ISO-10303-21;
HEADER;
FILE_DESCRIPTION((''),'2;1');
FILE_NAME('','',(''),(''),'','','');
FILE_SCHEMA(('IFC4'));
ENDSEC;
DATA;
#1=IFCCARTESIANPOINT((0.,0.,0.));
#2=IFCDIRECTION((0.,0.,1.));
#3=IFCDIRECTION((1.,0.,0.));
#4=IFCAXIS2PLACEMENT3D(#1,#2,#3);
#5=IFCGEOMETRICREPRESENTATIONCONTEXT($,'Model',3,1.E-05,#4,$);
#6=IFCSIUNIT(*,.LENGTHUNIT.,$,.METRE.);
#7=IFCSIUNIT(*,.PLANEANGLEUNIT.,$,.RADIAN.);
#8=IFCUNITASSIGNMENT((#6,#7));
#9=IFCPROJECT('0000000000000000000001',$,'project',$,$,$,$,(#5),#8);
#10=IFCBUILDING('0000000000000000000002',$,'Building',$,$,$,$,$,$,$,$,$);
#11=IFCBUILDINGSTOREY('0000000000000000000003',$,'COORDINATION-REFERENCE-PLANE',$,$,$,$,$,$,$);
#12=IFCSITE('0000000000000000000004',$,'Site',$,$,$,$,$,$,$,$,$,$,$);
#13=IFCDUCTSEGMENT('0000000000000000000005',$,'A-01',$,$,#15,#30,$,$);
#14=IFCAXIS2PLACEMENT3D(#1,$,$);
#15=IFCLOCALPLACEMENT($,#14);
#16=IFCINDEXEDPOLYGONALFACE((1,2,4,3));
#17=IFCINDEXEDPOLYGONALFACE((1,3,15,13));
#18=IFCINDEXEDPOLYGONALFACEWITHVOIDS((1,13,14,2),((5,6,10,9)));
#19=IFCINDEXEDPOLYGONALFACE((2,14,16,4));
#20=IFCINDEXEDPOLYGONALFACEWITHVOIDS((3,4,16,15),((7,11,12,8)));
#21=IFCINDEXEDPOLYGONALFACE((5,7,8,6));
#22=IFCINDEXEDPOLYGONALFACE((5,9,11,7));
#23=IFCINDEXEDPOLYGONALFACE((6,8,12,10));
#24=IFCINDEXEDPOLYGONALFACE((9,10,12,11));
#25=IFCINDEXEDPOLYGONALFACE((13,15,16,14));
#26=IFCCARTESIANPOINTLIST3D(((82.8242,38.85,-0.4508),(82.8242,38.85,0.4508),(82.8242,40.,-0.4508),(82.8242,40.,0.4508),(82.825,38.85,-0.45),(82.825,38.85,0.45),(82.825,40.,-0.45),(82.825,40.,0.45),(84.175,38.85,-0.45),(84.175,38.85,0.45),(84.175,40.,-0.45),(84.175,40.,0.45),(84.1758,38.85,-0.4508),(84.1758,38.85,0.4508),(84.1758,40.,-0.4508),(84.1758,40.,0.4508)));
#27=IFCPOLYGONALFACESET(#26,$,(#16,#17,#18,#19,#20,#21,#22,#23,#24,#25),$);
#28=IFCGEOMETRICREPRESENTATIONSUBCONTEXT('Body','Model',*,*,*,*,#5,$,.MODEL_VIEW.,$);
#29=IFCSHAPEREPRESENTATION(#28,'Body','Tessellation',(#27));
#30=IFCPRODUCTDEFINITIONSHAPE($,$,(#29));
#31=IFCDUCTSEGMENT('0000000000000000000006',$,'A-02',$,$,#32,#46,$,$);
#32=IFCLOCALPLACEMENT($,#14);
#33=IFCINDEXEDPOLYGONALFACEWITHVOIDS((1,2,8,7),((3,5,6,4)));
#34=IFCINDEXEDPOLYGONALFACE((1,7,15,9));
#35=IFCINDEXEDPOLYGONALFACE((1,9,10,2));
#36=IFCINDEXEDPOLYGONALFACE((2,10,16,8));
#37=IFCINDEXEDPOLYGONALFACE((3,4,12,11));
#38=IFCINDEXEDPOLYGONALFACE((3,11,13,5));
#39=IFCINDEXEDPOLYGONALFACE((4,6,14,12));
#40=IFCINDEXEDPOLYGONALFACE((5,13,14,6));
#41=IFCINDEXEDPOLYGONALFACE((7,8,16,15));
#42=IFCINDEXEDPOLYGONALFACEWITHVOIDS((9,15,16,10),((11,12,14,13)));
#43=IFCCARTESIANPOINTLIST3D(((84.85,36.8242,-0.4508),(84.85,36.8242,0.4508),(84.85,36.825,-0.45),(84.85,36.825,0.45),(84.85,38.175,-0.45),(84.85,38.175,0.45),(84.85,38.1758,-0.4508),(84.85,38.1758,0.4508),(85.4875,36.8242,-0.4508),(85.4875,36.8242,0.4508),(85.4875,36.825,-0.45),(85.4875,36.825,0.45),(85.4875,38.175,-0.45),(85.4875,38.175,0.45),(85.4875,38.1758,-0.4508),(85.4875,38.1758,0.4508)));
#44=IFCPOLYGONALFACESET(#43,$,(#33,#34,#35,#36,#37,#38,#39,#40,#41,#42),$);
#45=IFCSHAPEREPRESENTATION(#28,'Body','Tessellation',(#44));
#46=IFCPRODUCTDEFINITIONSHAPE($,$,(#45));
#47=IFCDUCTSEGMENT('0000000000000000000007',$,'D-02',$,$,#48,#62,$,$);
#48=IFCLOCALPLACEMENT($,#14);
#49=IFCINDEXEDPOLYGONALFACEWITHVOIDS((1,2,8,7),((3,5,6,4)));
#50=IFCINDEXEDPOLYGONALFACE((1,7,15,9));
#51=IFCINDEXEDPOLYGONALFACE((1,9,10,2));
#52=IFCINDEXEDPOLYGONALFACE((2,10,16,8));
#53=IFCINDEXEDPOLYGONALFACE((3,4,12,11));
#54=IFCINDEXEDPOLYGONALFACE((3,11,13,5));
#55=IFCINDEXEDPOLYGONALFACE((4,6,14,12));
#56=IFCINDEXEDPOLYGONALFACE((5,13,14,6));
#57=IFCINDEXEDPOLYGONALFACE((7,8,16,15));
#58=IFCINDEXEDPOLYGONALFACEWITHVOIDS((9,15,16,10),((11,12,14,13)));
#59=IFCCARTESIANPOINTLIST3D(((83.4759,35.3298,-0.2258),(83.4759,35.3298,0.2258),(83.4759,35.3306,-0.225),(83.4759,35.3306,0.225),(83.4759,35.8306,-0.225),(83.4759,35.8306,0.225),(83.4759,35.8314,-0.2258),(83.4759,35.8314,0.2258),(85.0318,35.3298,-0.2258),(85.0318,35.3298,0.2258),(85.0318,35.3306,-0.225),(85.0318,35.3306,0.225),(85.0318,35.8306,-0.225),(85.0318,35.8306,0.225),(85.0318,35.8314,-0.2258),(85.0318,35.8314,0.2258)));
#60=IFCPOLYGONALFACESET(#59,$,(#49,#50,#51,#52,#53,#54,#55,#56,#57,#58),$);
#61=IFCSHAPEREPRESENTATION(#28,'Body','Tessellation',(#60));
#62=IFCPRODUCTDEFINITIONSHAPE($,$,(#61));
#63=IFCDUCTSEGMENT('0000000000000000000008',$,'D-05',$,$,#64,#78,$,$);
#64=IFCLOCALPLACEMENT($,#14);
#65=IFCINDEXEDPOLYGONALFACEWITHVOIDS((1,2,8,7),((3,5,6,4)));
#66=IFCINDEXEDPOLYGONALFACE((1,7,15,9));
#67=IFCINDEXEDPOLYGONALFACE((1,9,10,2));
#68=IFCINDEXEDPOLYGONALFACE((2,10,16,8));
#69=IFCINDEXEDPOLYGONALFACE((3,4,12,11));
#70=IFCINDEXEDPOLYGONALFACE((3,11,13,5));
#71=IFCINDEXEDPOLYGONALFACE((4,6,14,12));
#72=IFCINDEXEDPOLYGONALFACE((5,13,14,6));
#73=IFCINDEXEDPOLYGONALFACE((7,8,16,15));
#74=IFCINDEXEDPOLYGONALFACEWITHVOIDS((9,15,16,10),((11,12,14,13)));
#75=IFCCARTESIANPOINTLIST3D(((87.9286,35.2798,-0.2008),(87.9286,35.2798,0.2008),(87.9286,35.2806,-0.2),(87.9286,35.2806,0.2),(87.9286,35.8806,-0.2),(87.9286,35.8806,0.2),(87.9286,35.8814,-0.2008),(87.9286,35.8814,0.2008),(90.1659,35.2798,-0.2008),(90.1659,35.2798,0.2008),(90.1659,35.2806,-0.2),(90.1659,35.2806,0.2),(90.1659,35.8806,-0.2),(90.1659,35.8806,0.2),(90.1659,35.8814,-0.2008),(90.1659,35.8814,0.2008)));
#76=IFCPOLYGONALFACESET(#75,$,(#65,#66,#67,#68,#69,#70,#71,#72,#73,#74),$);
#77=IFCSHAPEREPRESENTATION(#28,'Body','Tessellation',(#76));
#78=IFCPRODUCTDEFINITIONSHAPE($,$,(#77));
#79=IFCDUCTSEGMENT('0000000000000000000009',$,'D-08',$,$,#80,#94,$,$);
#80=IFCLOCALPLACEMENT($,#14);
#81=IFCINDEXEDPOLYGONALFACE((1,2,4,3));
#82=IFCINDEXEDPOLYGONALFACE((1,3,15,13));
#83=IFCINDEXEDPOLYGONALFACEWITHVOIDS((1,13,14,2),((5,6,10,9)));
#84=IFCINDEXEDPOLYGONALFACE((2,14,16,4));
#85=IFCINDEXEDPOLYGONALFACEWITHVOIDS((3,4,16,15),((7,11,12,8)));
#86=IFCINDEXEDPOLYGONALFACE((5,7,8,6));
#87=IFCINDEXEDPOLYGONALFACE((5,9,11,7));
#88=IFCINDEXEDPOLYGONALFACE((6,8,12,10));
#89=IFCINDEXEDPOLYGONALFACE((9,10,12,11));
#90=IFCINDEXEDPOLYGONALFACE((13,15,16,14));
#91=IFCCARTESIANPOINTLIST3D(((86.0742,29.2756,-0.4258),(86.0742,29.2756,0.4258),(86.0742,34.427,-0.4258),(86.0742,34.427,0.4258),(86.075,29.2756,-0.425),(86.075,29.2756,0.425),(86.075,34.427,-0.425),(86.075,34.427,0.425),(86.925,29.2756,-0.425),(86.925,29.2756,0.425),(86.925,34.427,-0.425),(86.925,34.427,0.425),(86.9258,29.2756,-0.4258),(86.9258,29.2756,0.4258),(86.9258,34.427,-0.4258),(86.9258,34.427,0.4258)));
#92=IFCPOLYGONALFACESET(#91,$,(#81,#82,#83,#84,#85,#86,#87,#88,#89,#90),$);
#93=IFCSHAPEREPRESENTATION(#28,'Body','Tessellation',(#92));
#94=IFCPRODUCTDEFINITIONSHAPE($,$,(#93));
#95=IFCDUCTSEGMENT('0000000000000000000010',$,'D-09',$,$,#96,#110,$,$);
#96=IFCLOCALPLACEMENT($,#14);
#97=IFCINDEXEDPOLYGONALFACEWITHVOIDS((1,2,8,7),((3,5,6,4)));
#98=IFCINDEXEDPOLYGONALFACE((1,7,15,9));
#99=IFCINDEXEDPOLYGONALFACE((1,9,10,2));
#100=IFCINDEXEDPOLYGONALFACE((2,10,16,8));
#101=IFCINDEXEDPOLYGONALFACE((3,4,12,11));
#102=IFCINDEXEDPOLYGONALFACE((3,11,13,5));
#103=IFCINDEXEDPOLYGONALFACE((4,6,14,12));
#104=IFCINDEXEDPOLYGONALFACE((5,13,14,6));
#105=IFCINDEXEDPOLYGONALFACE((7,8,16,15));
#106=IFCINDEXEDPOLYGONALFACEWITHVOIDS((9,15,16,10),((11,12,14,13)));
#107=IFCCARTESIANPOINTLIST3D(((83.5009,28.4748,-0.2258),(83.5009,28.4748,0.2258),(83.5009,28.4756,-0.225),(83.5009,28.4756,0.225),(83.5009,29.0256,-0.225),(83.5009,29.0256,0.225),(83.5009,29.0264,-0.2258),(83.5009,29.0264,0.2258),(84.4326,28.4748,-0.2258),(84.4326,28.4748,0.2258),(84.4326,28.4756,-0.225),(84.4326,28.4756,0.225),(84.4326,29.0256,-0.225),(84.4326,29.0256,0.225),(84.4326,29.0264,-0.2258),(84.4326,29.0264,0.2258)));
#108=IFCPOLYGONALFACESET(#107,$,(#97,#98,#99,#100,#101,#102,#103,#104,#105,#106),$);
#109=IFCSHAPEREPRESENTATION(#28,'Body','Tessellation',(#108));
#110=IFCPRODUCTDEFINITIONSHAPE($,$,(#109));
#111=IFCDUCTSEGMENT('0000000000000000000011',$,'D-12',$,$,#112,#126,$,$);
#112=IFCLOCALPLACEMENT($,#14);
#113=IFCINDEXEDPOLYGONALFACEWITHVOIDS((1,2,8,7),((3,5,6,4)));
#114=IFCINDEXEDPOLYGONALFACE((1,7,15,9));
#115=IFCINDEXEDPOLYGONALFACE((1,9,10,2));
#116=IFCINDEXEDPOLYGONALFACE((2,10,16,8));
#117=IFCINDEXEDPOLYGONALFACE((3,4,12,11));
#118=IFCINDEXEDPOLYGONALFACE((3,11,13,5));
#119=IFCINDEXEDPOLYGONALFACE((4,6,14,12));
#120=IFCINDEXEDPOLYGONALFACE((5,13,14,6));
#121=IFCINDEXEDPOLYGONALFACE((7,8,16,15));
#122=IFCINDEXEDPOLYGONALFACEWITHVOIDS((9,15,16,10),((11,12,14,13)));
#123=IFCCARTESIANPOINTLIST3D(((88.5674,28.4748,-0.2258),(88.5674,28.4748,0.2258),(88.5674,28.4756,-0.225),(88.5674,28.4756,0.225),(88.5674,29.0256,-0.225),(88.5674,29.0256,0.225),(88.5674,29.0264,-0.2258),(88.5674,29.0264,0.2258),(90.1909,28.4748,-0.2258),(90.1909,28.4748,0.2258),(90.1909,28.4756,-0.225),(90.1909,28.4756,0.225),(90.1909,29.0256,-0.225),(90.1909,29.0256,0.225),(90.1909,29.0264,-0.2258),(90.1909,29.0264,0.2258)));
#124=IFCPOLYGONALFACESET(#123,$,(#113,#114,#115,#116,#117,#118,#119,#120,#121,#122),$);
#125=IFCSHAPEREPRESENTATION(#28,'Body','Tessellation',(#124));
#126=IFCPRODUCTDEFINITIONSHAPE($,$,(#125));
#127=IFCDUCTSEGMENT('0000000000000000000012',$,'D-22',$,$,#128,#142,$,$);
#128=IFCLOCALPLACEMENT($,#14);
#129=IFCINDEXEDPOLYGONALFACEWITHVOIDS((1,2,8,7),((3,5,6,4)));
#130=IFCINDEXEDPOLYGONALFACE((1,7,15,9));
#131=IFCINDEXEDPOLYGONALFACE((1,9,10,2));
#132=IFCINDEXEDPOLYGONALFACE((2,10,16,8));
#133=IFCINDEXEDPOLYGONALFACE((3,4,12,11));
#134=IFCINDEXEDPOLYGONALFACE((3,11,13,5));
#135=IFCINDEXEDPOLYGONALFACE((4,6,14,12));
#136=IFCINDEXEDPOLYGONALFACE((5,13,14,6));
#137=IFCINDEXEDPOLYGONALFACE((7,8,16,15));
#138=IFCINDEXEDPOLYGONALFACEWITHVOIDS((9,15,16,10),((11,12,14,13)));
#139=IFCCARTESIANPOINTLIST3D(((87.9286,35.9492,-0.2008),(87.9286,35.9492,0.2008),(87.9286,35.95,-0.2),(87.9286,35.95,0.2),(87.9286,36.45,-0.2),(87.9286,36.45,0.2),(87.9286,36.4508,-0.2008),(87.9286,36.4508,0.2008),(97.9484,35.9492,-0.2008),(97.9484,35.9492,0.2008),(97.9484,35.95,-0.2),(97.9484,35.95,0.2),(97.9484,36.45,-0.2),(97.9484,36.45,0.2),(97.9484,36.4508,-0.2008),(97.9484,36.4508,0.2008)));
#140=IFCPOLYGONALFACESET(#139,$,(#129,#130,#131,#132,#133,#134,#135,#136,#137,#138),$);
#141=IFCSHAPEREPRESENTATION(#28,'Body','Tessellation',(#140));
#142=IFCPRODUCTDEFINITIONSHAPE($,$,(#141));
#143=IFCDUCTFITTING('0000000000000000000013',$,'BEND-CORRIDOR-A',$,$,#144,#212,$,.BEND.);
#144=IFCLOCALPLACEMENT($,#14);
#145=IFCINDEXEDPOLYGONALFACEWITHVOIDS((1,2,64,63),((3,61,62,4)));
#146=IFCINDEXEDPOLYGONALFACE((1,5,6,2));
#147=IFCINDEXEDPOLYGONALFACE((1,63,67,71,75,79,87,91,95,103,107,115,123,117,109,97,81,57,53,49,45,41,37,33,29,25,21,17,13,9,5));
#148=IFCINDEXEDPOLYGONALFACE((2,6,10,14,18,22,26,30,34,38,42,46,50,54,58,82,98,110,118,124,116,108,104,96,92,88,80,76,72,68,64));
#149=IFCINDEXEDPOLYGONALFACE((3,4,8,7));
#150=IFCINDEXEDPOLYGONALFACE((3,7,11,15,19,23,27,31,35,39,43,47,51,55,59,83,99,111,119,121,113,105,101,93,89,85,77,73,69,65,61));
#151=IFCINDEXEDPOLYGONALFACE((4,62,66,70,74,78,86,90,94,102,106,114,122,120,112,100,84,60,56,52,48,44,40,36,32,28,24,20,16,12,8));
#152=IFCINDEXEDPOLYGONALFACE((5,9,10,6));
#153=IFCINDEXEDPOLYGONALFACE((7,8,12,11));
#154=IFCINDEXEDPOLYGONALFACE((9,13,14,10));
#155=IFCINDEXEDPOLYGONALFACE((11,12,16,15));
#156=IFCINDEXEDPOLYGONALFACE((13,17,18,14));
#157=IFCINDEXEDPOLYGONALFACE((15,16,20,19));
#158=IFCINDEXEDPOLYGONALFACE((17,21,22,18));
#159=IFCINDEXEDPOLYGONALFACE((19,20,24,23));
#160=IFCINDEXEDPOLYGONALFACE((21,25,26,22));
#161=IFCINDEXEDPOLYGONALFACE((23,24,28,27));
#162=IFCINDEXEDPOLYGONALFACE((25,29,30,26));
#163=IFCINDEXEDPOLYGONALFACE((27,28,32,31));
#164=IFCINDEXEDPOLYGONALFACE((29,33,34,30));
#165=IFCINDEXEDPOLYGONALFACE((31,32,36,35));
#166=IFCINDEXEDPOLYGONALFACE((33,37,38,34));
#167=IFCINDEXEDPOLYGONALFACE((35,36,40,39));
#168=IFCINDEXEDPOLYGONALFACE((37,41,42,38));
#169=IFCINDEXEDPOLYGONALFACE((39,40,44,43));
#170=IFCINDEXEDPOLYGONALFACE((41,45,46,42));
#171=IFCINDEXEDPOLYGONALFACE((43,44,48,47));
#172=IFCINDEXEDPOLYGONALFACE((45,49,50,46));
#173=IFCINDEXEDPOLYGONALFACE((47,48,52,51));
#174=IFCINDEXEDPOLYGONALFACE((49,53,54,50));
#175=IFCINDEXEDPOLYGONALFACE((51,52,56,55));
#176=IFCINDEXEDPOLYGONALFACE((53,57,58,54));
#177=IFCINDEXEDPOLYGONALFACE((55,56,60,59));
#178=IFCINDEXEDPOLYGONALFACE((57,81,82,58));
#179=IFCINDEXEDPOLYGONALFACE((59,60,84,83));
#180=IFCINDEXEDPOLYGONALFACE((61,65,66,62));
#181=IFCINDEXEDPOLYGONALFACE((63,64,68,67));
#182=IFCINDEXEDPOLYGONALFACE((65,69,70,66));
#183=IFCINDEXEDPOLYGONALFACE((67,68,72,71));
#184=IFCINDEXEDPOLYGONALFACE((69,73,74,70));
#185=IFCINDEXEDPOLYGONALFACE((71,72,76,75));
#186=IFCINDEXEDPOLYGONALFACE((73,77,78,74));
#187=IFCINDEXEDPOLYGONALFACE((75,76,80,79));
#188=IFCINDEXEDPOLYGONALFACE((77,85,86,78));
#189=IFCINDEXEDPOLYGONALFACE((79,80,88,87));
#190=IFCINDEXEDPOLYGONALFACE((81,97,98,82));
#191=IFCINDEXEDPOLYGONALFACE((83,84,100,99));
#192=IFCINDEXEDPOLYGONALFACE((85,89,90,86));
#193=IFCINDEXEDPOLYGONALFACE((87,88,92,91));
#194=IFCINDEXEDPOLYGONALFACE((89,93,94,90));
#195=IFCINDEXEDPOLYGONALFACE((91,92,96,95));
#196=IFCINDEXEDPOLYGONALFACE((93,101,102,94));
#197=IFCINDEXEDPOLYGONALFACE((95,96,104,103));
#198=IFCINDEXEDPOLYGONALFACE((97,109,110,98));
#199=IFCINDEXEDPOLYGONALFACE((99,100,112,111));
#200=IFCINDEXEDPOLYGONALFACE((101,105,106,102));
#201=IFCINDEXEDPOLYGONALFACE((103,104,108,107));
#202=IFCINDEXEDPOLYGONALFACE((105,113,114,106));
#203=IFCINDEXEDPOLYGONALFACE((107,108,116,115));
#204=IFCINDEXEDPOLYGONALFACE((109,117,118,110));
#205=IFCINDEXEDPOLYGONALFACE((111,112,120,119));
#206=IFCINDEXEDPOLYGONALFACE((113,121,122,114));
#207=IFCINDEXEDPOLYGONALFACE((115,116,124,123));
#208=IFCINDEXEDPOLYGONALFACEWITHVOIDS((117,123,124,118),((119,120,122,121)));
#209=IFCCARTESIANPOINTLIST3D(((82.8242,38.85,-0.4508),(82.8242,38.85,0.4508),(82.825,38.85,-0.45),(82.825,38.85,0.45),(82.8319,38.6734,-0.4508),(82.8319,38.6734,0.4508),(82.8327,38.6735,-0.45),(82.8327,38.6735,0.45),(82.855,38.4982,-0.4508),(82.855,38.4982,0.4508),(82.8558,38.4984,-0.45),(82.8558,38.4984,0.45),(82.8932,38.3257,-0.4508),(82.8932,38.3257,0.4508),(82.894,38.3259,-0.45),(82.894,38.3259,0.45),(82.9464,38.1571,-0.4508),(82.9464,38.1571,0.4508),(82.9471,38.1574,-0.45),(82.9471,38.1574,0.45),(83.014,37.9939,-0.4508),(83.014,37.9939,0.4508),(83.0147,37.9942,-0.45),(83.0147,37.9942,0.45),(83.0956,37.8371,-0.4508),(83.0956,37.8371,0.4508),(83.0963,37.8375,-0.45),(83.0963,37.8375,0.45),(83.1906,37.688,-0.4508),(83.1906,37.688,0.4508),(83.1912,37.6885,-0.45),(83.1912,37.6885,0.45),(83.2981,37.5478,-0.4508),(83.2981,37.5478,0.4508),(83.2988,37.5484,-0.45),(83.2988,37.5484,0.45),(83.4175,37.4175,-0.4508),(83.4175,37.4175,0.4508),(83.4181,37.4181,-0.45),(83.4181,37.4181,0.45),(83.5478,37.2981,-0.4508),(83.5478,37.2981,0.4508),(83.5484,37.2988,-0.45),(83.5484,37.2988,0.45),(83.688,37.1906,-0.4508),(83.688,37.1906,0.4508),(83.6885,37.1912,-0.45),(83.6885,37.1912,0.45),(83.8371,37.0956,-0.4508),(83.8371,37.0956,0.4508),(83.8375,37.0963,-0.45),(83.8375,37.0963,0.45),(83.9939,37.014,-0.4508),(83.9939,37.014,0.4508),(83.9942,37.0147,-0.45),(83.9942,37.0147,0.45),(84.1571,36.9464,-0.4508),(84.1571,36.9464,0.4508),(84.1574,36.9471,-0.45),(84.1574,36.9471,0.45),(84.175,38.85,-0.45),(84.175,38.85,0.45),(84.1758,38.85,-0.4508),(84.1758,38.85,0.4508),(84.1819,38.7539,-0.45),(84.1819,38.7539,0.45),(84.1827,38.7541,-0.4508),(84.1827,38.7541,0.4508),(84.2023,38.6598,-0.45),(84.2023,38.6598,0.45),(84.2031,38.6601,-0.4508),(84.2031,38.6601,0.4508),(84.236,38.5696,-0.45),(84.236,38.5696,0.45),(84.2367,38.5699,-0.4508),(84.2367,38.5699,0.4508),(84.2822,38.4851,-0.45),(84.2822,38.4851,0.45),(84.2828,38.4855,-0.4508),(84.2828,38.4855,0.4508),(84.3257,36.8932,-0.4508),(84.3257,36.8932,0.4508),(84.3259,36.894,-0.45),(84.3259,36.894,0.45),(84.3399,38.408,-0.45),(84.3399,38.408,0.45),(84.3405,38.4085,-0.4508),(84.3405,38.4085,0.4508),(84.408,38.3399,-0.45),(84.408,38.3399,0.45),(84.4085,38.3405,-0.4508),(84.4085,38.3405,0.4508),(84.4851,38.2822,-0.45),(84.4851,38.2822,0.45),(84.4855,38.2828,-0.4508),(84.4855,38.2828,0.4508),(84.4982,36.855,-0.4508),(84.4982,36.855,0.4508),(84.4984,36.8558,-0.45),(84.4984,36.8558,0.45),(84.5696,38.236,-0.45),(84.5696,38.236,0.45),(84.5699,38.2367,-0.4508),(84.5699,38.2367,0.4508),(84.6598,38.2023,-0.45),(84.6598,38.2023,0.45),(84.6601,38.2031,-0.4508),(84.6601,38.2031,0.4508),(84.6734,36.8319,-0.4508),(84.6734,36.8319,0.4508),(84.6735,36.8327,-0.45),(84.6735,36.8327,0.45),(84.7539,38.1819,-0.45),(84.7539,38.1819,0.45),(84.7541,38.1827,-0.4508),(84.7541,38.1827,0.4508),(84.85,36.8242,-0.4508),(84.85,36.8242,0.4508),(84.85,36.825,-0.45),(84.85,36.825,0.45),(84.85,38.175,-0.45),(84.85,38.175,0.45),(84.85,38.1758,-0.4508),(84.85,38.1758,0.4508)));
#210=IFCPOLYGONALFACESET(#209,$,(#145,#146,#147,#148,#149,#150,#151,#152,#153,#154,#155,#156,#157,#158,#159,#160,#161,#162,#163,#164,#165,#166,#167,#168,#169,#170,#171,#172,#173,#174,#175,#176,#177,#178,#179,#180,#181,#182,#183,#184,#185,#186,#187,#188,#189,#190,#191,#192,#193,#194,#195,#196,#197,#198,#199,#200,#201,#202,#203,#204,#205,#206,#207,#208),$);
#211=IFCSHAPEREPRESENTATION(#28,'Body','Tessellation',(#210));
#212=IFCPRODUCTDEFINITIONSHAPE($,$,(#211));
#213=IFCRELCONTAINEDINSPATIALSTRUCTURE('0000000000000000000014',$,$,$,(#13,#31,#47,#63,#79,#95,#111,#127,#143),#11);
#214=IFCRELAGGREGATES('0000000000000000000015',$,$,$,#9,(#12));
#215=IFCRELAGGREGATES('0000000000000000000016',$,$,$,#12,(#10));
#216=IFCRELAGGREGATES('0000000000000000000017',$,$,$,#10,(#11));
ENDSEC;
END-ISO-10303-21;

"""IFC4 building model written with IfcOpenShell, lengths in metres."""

from ifc_helpers import new_model, entity, si_unit, frame, origin, origin_with_axes, place, context, subcontext, project, spatial, hollow_rectangle, extrude, element, save


model = new_model("IFC4")

# Units and contexts
model_context = context("Model", 3, precision=1e-05, world=origin_with_axes())
body_context_1 = subcontext(model_context, "Body", "Model", "MODEL_VIEW")
ifc_project = project(units=[si_unit("LENGTHUNIT", "METRE"), si_unit("PLANEANGLEUNIT", "RADIAN")], contexts=[model_context])

# Site, building, storey
site = spatial("IfcSite", under=ifc_project, Name="Site")
building = spatial("IfcBuilding", under=site, Name="Building")
storey = spatial("IfcBuildingStorey", under=building, Name="COORDINATION-REFERENCE-PLANE")

# Duct segments
duct_segment_1_placement = place(None, frame((83.5, 38.85, 0.0), z_axis=(0.0, 1.0, 0.0), x_axis=(1.0, 0.0, 0.0)))
element("IfcDuctSegment", 1, at=duct_segment_1_placement, inside=storey, Name="A-01", context=body_context_1, shape_type="SweptSolid", body=[
    extrude(hollow_rectangle(XDim=1.3516, YDim=0.9016, WallThickness=0.0008), origin(), (0.0, 0.0, 1.0), 1.15),
])
duct_segment_2_placement = place(None, frame((84.85, 37.5, 0.0), z_axis=(1.0, 0.0, 0.0), x_axis=(0.0, 1.0, 0.0)))
element("IfcDuctSegment", 2, at=duct_segment_2_placement, inside=storey, Name="A-02", context=body_context_1, shape_type="SweptSolid", body=[
    extrude(hollow_rectangle(XDim=1.3516, YDim=0.9016, WallThickness=0.0008), origin(), (0.0, 0.0, 1.0), 0.6375),
])
duct_segment_3_placement = place(None, frame((83.4759, 35.5806, 0.0), z_axis=(1.0, 0.0, 0.0), x_axis=(0.0, 1.0, 0.0)))
element("IfcDuctSegment", 3, at=duct_segment_3_placement, inside=storey, Name="D-02", context=body_context_1, shape_type="SweptSolid", body=[
    extrude(hollow_rectangle(XDim=0.5016, YDim=0.4516, WallThickness=0.0008), origin(), (0.0, 0.0, 1.0), 1.5559),
])
duct_segment_4_placement = place(None, frame((87.9286, 35.5806, 0.0), z_axis=(1.0, 0.0, 0.0), x_axis=(0.0, 1.0, 0.0)))
element("IfcDuctSegment", 4, at=duct_segment_4_placement, inside=storey, Name="D-05", context=body_context_1, shape_type="SweptSolid", body=[
    extrude(hollow_rectangle(XDim=0.6016, YDim=0.4016, WallThickness=0.0008), origin(), (0.0, 0.0, 1.0), 2.2374),
])
duct_segment_5_placement = place(None, frame((86.5, 29.2756, 0.0), z_axis=(0.0, 1.0, 0.0), x_axis=(1.0, 0.0, 0.0)))
element("IfcDuctSegment", 5, at=duct_segment_5_placement, inside=storey, Name="D-08", context=body_context_1, shape_type="SweptSolid", body=[
    extrude(hollow_rectangle(XDim=0.8516, YDim=0.8516, WallThickness=0.0008), origin(), (0.0, 0.0, 1.0), 5.1514),
])
duct_segment_6_placement = place(None, frame((83.5009, 28.7506, 0.0), z_axis=(1.0, 0.0, 0.0), x_axis=(0.0, 1.0, 0.0)))
element("IfcDuctSegment", 6, at=duct_segment_6_placement, inside=storey, Name="D-09", context=body_context_1, shape_type="SweptSolid", body=[
    extrude(hollow_rectangle(XDim=0.5516, YDim=0.4516, WallThickness=0.0008), origin(), (0.0, 0.0, 1.0), 0.9316),
])
duct_segment_7_placement = place(None, frame((88.5674, 28.7506, 0.0), z_axis=(1.0, 0.0, 0.0), x_axis=(0.0, 1.0, 0.0)))
element("IfcDuctSegment", 7, at=duct_segment_7_placement, inside=storey, Name="D-12", context=body_context_1, shape_type="SweptSolid", body=[
    extrude(hollow_rectangle(XDim=0.5516, YDim=0.4516, WallThickness=0.0008), origin(), (0.0, 0.0, 1.0), 1.6235),
])
duct_segment_8_placement = place(None, frame((87.9286, 36.2, 0.0), z_axis=(1.0, 0.0, 0.0), x_axis=(0.0, 1.0, 0.0)))
element("IfcDuctSegment", 8, at=duct_segment_8_placement, inside=storey, Name="D-22", context=body_context_1, shape_type="SweptSolid", body=[
    extrude(hollow_rectangle(XDim=0.5016, YDim=0.4016, WallThickness=0.0008), origin(), (0.0, 0.0, 1.0), 10.0199),
])

# Duct fitting
duct_fitting_1_placement = place(None, frame((84.85, 38.85, 0.0), z_axis=(0.0, 0.0, 1.0), x_axis=(-1.0, 0.0, 0.0)))
cartesian_point_1 = entity("IfcCartesianPoint", [0.0, 0.0, 0.0])
element("IfcDuctFitting", 9, at=duct_fitting_1_placement, inside=storey, Name="BEND-CORRIDOR-A", PredefinedType="BEND", context=body_context_1, shape_type="SweptSolid", body=[
    entity("IfcRevolvedAreaSolid", entity("IfcRectangleHollowProfileDef", "AREA", None, entity("IfcAxis2Placement2D", entity("IfcCartesianPoint", [1.35, 0.0])), 1.3516, 0.9016, 0.0008), entity("IfcAxis2Placement3D", cartesian_point_1, entity("IfcDirection", [0.0, -1.0, 0.0]), entity("IfcDirection", [1.0, 0.0, 0.0])), entity("IfcAxis1Placement", cartesian_point_1, entity("IfcDirection", [0.0, 1.0, 0.0])), 1.570796),
])

save(model, "model.ifc")
